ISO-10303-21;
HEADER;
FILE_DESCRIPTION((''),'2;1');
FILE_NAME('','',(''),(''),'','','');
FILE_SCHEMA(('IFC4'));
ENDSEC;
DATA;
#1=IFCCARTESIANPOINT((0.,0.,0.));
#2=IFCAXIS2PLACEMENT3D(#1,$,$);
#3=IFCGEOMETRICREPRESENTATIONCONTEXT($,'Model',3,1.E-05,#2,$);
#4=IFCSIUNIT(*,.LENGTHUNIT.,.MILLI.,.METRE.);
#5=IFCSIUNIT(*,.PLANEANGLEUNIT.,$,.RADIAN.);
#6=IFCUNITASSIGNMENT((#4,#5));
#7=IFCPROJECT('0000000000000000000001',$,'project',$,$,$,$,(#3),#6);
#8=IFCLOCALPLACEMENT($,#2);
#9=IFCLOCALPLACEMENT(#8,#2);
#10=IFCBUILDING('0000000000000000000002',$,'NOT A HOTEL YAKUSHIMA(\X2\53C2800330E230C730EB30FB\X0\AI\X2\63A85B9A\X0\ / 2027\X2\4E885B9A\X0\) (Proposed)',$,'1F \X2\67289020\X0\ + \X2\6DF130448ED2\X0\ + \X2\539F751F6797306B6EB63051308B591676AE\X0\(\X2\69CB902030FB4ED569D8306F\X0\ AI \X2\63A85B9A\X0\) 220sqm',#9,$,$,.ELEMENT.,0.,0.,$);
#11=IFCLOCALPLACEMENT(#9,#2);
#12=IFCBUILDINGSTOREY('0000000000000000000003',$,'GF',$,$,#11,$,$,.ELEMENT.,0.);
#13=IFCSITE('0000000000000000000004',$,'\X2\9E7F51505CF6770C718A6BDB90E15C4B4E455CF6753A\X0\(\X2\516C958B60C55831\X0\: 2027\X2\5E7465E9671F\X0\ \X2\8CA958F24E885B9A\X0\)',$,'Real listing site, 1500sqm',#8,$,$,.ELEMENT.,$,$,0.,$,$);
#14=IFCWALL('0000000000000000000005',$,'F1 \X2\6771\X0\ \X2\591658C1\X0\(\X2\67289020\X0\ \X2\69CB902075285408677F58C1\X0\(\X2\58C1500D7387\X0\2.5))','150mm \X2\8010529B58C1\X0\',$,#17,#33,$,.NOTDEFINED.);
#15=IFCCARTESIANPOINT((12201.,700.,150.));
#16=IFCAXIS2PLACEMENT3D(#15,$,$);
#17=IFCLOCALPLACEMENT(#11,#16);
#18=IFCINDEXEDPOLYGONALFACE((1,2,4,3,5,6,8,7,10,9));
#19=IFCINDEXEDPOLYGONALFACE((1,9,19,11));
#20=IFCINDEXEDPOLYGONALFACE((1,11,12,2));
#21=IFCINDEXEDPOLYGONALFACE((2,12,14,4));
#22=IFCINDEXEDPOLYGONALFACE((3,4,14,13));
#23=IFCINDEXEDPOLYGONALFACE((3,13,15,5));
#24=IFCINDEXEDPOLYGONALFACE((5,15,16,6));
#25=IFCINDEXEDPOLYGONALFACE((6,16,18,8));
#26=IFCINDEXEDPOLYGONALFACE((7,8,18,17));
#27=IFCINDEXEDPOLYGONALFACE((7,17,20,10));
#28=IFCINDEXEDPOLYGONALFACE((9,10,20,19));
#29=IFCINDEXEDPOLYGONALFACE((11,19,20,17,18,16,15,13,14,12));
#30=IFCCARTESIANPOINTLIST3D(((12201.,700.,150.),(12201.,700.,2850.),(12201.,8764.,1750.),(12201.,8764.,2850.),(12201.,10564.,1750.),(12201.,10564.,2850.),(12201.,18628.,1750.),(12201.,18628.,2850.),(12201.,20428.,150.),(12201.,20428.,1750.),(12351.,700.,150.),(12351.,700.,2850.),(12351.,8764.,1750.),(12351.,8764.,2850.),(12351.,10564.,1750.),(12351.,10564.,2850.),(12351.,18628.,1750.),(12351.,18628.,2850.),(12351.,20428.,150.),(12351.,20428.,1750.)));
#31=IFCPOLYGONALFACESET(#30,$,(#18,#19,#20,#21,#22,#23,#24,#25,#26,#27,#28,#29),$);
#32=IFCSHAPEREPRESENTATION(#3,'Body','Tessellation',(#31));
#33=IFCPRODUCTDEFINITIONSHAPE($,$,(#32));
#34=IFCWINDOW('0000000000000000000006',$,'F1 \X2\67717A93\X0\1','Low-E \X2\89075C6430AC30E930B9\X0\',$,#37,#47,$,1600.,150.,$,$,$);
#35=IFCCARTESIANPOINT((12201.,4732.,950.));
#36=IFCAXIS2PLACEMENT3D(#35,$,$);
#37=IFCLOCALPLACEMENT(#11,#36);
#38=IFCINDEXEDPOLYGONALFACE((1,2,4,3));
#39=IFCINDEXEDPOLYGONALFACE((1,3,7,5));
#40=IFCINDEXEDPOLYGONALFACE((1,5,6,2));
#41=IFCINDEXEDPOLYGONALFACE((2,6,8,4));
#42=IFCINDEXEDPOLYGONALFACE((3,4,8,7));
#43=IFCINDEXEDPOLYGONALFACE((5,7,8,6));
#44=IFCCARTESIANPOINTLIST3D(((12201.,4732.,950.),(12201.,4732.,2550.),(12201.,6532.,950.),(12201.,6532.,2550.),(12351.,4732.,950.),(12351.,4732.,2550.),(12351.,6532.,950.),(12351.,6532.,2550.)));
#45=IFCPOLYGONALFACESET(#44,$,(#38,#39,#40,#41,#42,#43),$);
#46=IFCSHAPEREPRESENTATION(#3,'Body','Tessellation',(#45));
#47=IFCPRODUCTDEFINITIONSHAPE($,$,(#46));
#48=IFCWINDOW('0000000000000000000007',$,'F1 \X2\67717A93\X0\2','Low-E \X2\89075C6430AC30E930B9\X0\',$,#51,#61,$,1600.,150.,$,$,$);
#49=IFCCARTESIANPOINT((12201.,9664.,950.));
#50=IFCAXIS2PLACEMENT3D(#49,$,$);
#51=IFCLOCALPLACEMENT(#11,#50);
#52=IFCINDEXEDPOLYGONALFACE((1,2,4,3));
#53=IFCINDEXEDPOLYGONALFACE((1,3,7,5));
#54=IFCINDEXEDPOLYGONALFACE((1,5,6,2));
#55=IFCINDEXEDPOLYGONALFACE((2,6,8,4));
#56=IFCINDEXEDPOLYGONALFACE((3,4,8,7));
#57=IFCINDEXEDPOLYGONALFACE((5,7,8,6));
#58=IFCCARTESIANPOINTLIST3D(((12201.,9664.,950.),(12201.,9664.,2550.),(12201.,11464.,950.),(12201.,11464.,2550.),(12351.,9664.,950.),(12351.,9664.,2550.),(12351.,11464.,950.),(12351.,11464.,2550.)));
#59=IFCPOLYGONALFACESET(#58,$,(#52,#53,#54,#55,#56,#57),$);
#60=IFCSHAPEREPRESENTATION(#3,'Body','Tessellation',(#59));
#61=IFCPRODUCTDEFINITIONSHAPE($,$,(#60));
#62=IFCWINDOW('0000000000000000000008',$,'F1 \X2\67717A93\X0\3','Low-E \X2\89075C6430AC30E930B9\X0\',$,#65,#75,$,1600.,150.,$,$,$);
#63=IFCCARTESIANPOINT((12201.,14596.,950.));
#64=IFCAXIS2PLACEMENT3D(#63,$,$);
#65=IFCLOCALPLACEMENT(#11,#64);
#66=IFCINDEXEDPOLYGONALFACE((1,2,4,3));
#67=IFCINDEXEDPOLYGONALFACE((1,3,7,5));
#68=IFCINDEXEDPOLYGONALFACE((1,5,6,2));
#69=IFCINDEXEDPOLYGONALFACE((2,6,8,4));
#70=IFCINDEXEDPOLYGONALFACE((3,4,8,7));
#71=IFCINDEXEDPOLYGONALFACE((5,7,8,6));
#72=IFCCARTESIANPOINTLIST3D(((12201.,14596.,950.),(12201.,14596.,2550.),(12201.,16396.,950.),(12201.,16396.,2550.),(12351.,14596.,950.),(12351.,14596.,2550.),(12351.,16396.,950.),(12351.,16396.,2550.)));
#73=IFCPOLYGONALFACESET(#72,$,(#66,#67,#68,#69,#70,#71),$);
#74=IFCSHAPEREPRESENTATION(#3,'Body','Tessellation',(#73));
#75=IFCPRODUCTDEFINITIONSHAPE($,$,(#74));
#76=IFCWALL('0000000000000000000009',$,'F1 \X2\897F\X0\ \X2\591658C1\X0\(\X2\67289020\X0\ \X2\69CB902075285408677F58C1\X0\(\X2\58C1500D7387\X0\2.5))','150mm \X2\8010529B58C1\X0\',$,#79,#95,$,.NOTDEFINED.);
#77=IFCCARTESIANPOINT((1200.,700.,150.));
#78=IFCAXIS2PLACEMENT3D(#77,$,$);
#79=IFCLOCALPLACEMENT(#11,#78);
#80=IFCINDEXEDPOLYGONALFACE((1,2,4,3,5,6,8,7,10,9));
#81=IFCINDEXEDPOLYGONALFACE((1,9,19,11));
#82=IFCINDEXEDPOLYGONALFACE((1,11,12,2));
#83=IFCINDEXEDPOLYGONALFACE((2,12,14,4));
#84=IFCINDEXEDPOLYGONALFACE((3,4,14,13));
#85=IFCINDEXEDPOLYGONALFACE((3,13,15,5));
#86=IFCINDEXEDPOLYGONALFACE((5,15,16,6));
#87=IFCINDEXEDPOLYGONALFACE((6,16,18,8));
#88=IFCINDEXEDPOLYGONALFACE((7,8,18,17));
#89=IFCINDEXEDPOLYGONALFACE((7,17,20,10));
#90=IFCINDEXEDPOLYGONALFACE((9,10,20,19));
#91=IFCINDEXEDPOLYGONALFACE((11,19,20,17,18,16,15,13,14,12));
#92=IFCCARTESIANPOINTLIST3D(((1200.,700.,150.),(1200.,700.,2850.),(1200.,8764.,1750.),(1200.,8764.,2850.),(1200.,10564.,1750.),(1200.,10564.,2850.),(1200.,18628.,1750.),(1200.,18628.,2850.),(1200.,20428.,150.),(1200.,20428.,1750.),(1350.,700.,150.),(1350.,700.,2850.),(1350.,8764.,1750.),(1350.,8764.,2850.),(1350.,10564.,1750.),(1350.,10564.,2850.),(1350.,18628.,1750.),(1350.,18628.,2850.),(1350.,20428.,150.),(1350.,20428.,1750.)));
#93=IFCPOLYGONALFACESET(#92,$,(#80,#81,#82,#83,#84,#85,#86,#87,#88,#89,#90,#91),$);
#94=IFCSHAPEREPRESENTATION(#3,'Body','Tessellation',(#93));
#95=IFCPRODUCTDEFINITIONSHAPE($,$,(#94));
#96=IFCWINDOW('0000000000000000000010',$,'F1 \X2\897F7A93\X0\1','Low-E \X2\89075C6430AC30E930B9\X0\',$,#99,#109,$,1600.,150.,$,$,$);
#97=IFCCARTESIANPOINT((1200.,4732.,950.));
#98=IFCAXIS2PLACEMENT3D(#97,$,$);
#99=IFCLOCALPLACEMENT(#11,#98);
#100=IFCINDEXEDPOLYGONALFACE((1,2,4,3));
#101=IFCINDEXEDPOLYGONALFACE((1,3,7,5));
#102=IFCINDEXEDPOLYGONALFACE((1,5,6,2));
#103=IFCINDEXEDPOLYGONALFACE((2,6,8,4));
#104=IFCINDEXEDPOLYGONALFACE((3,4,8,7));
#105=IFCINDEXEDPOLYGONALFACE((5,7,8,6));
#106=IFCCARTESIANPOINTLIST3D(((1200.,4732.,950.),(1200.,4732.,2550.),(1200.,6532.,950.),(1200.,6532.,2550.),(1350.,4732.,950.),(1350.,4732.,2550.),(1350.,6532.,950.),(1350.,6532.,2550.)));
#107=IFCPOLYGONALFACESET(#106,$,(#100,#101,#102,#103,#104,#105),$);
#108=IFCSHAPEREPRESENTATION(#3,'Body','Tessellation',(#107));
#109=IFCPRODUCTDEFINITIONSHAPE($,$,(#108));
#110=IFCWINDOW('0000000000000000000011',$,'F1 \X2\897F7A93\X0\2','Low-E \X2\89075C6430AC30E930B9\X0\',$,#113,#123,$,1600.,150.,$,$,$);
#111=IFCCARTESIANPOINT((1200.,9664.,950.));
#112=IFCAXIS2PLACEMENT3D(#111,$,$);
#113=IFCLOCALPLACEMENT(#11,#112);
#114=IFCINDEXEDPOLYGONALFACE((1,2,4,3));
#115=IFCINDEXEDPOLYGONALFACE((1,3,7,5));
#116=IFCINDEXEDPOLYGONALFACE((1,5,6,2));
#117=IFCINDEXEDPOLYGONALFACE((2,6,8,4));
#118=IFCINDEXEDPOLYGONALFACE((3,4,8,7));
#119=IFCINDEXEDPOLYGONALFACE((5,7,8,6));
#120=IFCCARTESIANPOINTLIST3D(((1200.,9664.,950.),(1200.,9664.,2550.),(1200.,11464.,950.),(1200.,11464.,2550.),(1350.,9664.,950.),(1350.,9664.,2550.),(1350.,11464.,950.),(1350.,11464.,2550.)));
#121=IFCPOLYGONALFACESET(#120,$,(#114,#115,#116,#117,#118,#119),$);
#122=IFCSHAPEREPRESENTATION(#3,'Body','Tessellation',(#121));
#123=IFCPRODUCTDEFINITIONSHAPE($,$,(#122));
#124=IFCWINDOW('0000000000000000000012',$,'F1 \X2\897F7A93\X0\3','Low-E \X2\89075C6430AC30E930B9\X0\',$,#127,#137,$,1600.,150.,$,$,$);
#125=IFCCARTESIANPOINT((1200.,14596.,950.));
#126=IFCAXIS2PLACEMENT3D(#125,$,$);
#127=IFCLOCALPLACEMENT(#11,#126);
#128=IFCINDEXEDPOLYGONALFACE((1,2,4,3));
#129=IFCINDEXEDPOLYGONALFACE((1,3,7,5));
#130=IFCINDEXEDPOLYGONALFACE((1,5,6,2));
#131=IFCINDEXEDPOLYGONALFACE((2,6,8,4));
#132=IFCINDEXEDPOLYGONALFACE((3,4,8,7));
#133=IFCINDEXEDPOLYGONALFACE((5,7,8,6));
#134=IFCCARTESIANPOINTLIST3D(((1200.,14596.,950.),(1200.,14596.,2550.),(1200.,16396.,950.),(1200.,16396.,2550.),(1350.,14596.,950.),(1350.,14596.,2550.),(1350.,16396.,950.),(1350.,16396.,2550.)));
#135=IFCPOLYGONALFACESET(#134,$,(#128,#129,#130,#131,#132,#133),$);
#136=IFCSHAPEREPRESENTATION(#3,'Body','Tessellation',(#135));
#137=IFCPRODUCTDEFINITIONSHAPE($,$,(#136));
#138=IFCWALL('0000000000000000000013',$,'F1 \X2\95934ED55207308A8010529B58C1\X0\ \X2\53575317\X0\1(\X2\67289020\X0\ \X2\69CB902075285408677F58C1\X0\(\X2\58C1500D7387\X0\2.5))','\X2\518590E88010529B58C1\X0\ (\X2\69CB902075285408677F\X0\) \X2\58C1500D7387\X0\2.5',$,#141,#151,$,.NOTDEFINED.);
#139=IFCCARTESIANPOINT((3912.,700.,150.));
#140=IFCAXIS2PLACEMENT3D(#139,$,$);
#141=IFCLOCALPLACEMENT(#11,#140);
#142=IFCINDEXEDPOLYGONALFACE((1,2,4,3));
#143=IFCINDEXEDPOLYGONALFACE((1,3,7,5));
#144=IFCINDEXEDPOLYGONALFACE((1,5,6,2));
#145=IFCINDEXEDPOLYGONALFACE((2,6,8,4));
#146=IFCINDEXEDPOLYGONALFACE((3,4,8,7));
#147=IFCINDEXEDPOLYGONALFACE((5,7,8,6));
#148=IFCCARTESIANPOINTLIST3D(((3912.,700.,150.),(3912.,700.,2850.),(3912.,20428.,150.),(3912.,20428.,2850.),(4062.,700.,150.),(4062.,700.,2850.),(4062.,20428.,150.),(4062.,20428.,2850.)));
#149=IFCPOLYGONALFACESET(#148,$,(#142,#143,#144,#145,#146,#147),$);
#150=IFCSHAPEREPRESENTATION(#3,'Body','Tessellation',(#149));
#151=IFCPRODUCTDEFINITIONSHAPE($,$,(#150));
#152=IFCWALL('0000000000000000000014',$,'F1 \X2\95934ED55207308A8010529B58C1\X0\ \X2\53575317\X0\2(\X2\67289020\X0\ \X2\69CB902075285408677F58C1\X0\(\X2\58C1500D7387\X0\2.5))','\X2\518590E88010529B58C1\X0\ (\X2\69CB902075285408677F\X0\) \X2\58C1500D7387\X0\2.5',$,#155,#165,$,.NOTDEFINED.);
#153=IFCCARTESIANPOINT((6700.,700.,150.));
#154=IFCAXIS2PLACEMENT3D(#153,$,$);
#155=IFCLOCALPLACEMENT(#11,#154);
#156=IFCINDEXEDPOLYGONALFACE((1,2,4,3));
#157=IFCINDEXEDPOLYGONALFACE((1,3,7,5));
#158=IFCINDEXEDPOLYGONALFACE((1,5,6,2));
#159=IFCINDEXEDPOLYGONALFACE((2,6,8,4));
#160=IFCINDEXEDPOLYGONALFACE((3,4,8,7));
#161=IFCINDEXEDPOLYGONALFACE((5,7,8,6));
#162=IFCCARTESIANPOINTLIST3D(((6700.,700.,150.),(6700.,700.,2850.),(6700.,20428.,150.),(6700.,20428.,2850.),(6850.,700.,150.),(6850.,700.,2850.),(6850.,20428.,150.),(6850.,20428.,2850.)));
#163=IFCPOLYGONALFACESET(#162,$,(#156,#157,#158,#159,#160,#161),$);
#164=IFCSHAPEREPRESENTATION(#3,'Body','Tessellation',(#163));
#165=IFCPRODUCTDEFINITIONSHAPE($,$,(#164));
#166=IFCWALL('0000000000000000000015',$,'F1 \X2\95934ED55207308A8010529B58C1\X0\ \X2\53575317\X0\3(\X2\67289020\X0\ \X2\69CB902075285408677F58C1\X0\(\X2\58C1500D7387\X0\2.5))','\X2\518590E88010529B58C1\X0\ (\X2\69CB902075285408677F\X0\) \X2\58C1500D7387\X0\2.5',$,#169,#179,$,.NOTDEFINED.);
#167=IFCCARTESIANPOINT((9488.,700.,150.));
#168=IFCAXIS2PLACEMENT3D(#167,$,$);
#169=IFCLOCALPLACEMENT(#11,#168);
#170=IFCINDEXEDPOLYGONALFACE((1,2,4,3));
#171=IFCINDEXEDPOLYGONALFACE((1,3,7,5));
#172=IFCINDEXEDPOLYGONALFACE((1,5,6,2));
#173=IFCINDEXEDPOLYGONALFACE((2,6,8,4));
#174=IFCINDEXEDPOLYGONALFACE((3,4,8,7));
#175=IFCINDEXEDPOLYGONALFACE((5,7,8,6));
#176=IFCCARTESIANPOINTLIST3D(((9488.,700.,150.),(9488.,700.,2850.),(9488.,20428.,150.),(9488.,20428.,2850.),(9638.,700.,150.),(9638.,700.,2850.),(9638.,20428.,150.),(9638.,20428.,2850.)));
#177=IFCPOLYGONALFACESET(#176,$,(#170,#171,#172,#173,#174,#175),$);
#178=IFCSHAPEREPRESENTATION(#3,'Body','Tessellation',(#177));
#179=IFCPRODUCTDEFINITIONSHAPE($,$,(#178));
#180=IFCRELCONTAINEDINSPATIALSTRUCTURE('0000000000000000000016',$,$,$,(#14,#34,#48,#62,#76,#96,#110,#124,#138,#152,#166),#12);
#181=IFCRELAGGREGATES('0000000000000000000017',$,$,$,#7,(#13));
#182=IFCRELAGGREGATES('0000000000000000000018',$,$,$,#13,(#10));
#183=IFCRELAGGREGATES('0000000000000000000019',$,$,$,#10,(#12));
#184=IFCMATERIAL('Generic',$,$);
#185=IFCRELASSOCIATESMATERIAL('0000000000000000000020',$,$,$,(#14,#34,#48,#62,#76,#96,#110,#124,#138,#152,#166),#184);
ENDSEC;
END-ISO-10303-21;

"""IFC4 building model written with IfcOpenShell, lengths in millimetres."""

from ifc_helpers import new_model, si_unit, frame, frame_2d, origin, place, context, project, spatial, rectangle, extrude, material, element, fill, save


model = new_model("IFC4")

# Units and contexts
model_context = context("Model", 3, precision=1e-05, world=origin())
ifc_project = project(units=[si_unit("LENGTHUNIT", "METRE", prefix="MILLI"), si_unit("PLANEANGLEUNIT", "RADIAN")], contexts=[model_context])

# Site, building, storey
site_placement = place(None, origin())
site = spatial("IfcSite", under=ifc_project, at=site_placement, Name="鹿児島県熊毛郡屋久島町(公開情報: 2027年早期 販売予定)", ObjectType="Real listing site, 1500sqm", CompositionType="ELEMENT", RefElevation=0.0)
building_placement = place(site_placement, origin())
building = spatial("IfcBuilding", under=site, at=building_placement, Name="NOT A HOTEL YAKUSHIMA(参考モデル・AI推定 / 2027予定) (Proposed)", ObjectType="1F 木造 + 深い軒 + 原生林に溶ける外皮(構造・仕様は AI 推定) 220sqm", CompositionType="ELEMENT", ElevationOfRefHeight=0.0, ElevationOfTerrain=0.0)
storey_placement = place(building_placement, origin())
storey = spatial("IfcBuildingStorey", under=building, at=storey_placement, Name="GF", CompositionType="ELEMENT", Elevation=0.0)

# Shared definitions
ifc_material_1 = material(Name="Generic")

# Walls, openings, windows
wall_1_placement = place(storey_placement, frame((12201.0, 700.0, 150.0)))
wall_1 = element("IfcWall", 1, at=wall_1_placement, inside=storey, material=ifc_material_1, Name="F1 東 外壁(木造 構造用合板壁(壁倍率2.5))", Description="150mm 耐力壁", PredefinedType="NOTDEFINED", context=model_context, shape_type="SweptSolid", body=[
    extrude(rectangle(XDim=150.0, YDim=19728.0, at=frame_2d((75.0, 9864.0))), frame((12201.0, 700.0, 150.0)), (0.0, 0.0, 1.0), 2700.0),
])
opening_1_placement = place(storey_placement, frame((12201.0, 4732.0, 950.0)))
opening_1 = element("IfcOpeningElement", 2, at=opening_1_placement, cuts=wall_1, PredefinedType="NOTDEFINED", context=model_context, shape_type="SweptSolid", body=[
    extrude(rectangle(XDim=150.0, YDim=1800.0, at=frame_2d((75.0, 900.0))), frame((12201.0, 4732.0, 950.0)), (0.0, 0.0, 1.0), 1600.0),
])
opening_2_placement = place(storey_placement, frame((12201.0, 9664.0, 950.0)))
opening_2 = element("IfcOpeningElement", 3, at=opening_2_placement, cuts=wall_1, PredefinedType="NOTDEFINED", context=model_context, shape_type="SweptSolid", body=[
    extrude(rectangle(XDim=150.0, YDim=1800.0, at=frame_2d((75.0, 900.0))), frame((12201.0, 9664.0, 950.0)), (0.0, 0.0, 1.0), 1600.0),
])
opening_3_placement = place(storey_placement, frame((12201.0, 14596.0, 950.0)))
opening_3 = element("IfcOpeningElement", 4, at=opening_3_placement, cuts=wall_1, PredefinedType="NOTDEFINED", context=model_context, shape_type="SweptSolid", body=[
    extrude(rectangle(XDim=150.0, YDim=1800.0, at=frame_2d((75.0, 900.0))), frame((12201.0, 14596.0, 950.0)), (0.0, 0.0, 1.0), 1600.0),
])
window_1_placement = place(storey_placement, frame((12201.0, 4732.0, 950.0)))
window_1 = element("IfcWindow", 5, at=window_1_placement, inside=storey, material=ifc_material_1, Name="F1 東窓1", Description="Low-E 複層ガラス", OverallHeight=1600.0, OverallWidth=150.0, context=model_context, shape_type="SweptSolid", body=[
    extrude(rectangle(XDim=150.0, YDim=1800.0, at=frame_2d((75.0, 900.0))), frame((12201.0, 4732.0, 950.0)), (0.0, 0.0, 1.0), 1600.0),
])
fill(opening_1, window_1)
window_2_placement = place(storey_placement, frame((12201.0, 9664.0, 950.0)))
window_2 = element("IfcWindow", 6, at=window_2_placement, inside=storey, material=ifc_material_1, Name="F1 東窓2", Description="Low-E 複層ガラス", OverallHeight=1600.0, OverallWidth=150.0, context=model_context, shape_type="SweptSolid", body=[
    extrude(rectangle(XDim=150.0, YDim=1800.0, at=frame_2d((75.0, 900.0))), frame((12201.0, 9664.0, 950.0)), (0.0, 0.0, 1.0), 1600.0),
])
fill(opening_2, window_2)
window_3_placement = place(storey_placement, frame((12201.0, 14596.0, 950.0)))
window_3 = element("IfcWindow", 7, at=window_3_placement, inside=storey, material=ifc_material_1, Name="F1 東窓3", Description="Low-E 複層ガラス", OverallHeight=1600.0, OverallWidth=150.0, context=model_context, shape_type="SweptSolid", body=[
    extrude(rectangle(XDim=150.0, YDim=1800.0, at=frame_2d((75.0, 900.0))), frame((12201.0, 14596.0, 950.0)), (0.0, 0.0, 1.0), 1600.0),
])
fill(opening_3, window_3)
wall_2_placement = place(storey_placement, frame((1200.0, 700.0, 150.0)))
wall_2 = element("IfcWall", 8, at=wall_2_placement, inside=storey, material=ifc_material_1, Name="F1 西 外壁(木造 構造用合板壁(壁倍率2.5))", Description="150mm 耐力壁", PredefinedType="NOTDEFINED", context=model_context, shape_type="SweptSolid", body=[
    extrude(rectangle(XDim=150.0, YDim=19728.0, at=frame_2d((75.0, 9864.0))), frame((1200.0, 700.0, 150.0)), (0.0, 0.0, 1.0), 2700.0),
])
opening_4_placement = place(storey_placement, frame((1200.0, 4732.0, 950.0)))
opening_4 = element("IfcOpeningElement", 9, at=opening_4_placement, cuts=wall_2, PredefinedType="NOTDEFINED", context=model_context, shape_type="SweptSolid", body=[
    extrude(rectangle(XDim=150.0, YDim=1800.0, at=frame_2d((75.0, 900.0))), frame((1200.0, 4732.0, 950.0)), (0.0, 0.0, 1.0), 1600.0),
])
opening_5_placement = place(storey_placement, frame((1200.0, 9664.0, 950.0)))
opening_5 = element("IfcOpeningElement", 10, at=opening_5_placement, cuts=wall_2, PredefinedType="NOTDEFINED", context=model_context, shape_type="SweptSolid", body=[
    extrude(rectangle(XDim=150.0, YDim=1800.0, at=frame_2d((75.0, 900.0))), frame((1200.0, 9664.0, 950.0)), (0.0, 0.0, 1.0), 1600.0),
])
opening_6_placement = place(storey_placement, frame((1200.0, 14596.0, 950.0)))
opening_6 = element("IfcOpeningElement", 11, at=opening_6_placement, cuts=wall_2, PredefinedType="NOTDEFINED", context=model_context, shape_type="SweptSolid", body=[
    extrude(rectangle(XDim=150.0, YDim=1800.0, at=frame_2d((75.0, 900.0))), frame((1200.0, 14596.0, 950.0)), (0.0, 0.0, 1.0), 1600.0),
])
window_4_placement = place(storey_placement, frame((1200.0, 4732.0, 950.0)))
window_4 = element("IfcWindow", 12, at=window_4_placement, inside=storey, material=ifc_material_1, Name="F1 西窓1", Description="Low-E 複層ガラス", OverallHeight=1600.0, OverallWidth=150.0, context=model_context, shape_type="SweptSolid", body=[
    extrude(rectangle(XDim=150.0, YDim=1800.0, at=frame_2d((75.0, 900.0))), frame((1200.0, 4732.0, 950.0)), (0.0, 0.0, 1.0), 1600.0),
])
fill(opening_4, window_4)
window_5_placement = place(storey_placement, frame((1200.0, 9664.0, 950.0)))
window_5 = element("IfcWindow", 13, at=window_5_placement, inside=storey, material=ifc_material_1, Name="F1 西窓2", Description="Low-E 複層ガラス", OverallHeight=1600.0, OverallWidth=150.0, context=model_context, shape_type="SweptSolid", body=[
    extrude(rectangle(XDim=150.0, YDim=1800.0, at=frame_2d((75.0, 900.0))), frame((1200.0, 9664.0, 950.0)), (0.0, 0.0, 1.0), 1600.0),
])
fill(opening_5, window_5)
window_6_placement = place(storey_placement, frame((1200.0, 14596.0, 950.0)))
window_6 = element("IfcWindow", 14, at=window_6_placement, inside=storey, material=ifc_material_1, Name="F1 西窓3", Description="Low-E 複層ガラス", OverallHeight=1600.0, OverallWidth=150.0, context=model_context, shape_type="SweptSolid", body=[
    extrude(rectangle(XDim=150.0, YDim=1800.0, at=frame_2d((75.0, 900.0))), frame((1200.0, 14596.0, 950.0)), (0.0, 0.0, 1.0), 1600.0),
])
fill(opening_6, window_6)

# Walls
wall_3_placement = place(storey_placement, frame((3912.0, 700.0, 150.0)))
element("IfcWall", 15, at=wall_3_placement, inside=storey, material=ifc_material_1, Name="F1 間仕切り耐力壁 南北1(木造 構造用合板壁(壁倍率2.5))", Description="内部耐力壁 (構造用合板) 壁倍率2.5", PredefinedType="NOTDEFINED", context=model_context, shape_type="SweptSolid", body=[
    extrude(rectangle(XDim=150.0, YDim=19728.0, at=frame_2d((75.0, 9864.0))), frame((3912.0, 700.0, 150.0)), (0.0, 0.0, 1.0), 2700.0),
])
wall_4_placement = place(storey_placement, frame((6700.0, 700.0, 150.0)))
element("IfcWall", 16, at=wall_4_placement, inside=storey, material=ifc_material_1, Name="F1 間仕切り耐力壁 南北2(木造 構造用合板壁(壁倍率2.5))", Description="内部耐力壁 (構造用合板) 壁倍率2.5", PredefinedType="NOTDEFINED", context=model_context, shape_type="SweptSolid", body=[
    extrude(rectangle(XDim=150.0, YDim=19728.0, at=frame_2d((75.0, 9864.0))), frame((6700.0, 700.0, 150.0)), (0.0, 0.0, 1.0), 2700.0),
])
wall_5_placement = place(storey_placement, frame((9488.0, 700.0, 150.0)))
element("IfcWall", 17, at=wall_5_placement, inside=storey, material=ifc_material_1, Name="F1 間仕切り耐力壁 南北3(木造 構造用合板壁(壁倍率2.5))", Description="内部耐力壁 (構造用合板) 壁倍率2.5", PredefinedType="NOTDEFINED", context=model_context, shape_type="SweptSolid", body=[
    extrude(rectangle(XDim=150.0, YDim=19728.0, at=frame_2d((75.0, 9864.0))), frame((9488.0, 700.0, 150.0)), (0.0, 0.0, 1.0), 2700.0),
])

save(model, "model.ifc")
